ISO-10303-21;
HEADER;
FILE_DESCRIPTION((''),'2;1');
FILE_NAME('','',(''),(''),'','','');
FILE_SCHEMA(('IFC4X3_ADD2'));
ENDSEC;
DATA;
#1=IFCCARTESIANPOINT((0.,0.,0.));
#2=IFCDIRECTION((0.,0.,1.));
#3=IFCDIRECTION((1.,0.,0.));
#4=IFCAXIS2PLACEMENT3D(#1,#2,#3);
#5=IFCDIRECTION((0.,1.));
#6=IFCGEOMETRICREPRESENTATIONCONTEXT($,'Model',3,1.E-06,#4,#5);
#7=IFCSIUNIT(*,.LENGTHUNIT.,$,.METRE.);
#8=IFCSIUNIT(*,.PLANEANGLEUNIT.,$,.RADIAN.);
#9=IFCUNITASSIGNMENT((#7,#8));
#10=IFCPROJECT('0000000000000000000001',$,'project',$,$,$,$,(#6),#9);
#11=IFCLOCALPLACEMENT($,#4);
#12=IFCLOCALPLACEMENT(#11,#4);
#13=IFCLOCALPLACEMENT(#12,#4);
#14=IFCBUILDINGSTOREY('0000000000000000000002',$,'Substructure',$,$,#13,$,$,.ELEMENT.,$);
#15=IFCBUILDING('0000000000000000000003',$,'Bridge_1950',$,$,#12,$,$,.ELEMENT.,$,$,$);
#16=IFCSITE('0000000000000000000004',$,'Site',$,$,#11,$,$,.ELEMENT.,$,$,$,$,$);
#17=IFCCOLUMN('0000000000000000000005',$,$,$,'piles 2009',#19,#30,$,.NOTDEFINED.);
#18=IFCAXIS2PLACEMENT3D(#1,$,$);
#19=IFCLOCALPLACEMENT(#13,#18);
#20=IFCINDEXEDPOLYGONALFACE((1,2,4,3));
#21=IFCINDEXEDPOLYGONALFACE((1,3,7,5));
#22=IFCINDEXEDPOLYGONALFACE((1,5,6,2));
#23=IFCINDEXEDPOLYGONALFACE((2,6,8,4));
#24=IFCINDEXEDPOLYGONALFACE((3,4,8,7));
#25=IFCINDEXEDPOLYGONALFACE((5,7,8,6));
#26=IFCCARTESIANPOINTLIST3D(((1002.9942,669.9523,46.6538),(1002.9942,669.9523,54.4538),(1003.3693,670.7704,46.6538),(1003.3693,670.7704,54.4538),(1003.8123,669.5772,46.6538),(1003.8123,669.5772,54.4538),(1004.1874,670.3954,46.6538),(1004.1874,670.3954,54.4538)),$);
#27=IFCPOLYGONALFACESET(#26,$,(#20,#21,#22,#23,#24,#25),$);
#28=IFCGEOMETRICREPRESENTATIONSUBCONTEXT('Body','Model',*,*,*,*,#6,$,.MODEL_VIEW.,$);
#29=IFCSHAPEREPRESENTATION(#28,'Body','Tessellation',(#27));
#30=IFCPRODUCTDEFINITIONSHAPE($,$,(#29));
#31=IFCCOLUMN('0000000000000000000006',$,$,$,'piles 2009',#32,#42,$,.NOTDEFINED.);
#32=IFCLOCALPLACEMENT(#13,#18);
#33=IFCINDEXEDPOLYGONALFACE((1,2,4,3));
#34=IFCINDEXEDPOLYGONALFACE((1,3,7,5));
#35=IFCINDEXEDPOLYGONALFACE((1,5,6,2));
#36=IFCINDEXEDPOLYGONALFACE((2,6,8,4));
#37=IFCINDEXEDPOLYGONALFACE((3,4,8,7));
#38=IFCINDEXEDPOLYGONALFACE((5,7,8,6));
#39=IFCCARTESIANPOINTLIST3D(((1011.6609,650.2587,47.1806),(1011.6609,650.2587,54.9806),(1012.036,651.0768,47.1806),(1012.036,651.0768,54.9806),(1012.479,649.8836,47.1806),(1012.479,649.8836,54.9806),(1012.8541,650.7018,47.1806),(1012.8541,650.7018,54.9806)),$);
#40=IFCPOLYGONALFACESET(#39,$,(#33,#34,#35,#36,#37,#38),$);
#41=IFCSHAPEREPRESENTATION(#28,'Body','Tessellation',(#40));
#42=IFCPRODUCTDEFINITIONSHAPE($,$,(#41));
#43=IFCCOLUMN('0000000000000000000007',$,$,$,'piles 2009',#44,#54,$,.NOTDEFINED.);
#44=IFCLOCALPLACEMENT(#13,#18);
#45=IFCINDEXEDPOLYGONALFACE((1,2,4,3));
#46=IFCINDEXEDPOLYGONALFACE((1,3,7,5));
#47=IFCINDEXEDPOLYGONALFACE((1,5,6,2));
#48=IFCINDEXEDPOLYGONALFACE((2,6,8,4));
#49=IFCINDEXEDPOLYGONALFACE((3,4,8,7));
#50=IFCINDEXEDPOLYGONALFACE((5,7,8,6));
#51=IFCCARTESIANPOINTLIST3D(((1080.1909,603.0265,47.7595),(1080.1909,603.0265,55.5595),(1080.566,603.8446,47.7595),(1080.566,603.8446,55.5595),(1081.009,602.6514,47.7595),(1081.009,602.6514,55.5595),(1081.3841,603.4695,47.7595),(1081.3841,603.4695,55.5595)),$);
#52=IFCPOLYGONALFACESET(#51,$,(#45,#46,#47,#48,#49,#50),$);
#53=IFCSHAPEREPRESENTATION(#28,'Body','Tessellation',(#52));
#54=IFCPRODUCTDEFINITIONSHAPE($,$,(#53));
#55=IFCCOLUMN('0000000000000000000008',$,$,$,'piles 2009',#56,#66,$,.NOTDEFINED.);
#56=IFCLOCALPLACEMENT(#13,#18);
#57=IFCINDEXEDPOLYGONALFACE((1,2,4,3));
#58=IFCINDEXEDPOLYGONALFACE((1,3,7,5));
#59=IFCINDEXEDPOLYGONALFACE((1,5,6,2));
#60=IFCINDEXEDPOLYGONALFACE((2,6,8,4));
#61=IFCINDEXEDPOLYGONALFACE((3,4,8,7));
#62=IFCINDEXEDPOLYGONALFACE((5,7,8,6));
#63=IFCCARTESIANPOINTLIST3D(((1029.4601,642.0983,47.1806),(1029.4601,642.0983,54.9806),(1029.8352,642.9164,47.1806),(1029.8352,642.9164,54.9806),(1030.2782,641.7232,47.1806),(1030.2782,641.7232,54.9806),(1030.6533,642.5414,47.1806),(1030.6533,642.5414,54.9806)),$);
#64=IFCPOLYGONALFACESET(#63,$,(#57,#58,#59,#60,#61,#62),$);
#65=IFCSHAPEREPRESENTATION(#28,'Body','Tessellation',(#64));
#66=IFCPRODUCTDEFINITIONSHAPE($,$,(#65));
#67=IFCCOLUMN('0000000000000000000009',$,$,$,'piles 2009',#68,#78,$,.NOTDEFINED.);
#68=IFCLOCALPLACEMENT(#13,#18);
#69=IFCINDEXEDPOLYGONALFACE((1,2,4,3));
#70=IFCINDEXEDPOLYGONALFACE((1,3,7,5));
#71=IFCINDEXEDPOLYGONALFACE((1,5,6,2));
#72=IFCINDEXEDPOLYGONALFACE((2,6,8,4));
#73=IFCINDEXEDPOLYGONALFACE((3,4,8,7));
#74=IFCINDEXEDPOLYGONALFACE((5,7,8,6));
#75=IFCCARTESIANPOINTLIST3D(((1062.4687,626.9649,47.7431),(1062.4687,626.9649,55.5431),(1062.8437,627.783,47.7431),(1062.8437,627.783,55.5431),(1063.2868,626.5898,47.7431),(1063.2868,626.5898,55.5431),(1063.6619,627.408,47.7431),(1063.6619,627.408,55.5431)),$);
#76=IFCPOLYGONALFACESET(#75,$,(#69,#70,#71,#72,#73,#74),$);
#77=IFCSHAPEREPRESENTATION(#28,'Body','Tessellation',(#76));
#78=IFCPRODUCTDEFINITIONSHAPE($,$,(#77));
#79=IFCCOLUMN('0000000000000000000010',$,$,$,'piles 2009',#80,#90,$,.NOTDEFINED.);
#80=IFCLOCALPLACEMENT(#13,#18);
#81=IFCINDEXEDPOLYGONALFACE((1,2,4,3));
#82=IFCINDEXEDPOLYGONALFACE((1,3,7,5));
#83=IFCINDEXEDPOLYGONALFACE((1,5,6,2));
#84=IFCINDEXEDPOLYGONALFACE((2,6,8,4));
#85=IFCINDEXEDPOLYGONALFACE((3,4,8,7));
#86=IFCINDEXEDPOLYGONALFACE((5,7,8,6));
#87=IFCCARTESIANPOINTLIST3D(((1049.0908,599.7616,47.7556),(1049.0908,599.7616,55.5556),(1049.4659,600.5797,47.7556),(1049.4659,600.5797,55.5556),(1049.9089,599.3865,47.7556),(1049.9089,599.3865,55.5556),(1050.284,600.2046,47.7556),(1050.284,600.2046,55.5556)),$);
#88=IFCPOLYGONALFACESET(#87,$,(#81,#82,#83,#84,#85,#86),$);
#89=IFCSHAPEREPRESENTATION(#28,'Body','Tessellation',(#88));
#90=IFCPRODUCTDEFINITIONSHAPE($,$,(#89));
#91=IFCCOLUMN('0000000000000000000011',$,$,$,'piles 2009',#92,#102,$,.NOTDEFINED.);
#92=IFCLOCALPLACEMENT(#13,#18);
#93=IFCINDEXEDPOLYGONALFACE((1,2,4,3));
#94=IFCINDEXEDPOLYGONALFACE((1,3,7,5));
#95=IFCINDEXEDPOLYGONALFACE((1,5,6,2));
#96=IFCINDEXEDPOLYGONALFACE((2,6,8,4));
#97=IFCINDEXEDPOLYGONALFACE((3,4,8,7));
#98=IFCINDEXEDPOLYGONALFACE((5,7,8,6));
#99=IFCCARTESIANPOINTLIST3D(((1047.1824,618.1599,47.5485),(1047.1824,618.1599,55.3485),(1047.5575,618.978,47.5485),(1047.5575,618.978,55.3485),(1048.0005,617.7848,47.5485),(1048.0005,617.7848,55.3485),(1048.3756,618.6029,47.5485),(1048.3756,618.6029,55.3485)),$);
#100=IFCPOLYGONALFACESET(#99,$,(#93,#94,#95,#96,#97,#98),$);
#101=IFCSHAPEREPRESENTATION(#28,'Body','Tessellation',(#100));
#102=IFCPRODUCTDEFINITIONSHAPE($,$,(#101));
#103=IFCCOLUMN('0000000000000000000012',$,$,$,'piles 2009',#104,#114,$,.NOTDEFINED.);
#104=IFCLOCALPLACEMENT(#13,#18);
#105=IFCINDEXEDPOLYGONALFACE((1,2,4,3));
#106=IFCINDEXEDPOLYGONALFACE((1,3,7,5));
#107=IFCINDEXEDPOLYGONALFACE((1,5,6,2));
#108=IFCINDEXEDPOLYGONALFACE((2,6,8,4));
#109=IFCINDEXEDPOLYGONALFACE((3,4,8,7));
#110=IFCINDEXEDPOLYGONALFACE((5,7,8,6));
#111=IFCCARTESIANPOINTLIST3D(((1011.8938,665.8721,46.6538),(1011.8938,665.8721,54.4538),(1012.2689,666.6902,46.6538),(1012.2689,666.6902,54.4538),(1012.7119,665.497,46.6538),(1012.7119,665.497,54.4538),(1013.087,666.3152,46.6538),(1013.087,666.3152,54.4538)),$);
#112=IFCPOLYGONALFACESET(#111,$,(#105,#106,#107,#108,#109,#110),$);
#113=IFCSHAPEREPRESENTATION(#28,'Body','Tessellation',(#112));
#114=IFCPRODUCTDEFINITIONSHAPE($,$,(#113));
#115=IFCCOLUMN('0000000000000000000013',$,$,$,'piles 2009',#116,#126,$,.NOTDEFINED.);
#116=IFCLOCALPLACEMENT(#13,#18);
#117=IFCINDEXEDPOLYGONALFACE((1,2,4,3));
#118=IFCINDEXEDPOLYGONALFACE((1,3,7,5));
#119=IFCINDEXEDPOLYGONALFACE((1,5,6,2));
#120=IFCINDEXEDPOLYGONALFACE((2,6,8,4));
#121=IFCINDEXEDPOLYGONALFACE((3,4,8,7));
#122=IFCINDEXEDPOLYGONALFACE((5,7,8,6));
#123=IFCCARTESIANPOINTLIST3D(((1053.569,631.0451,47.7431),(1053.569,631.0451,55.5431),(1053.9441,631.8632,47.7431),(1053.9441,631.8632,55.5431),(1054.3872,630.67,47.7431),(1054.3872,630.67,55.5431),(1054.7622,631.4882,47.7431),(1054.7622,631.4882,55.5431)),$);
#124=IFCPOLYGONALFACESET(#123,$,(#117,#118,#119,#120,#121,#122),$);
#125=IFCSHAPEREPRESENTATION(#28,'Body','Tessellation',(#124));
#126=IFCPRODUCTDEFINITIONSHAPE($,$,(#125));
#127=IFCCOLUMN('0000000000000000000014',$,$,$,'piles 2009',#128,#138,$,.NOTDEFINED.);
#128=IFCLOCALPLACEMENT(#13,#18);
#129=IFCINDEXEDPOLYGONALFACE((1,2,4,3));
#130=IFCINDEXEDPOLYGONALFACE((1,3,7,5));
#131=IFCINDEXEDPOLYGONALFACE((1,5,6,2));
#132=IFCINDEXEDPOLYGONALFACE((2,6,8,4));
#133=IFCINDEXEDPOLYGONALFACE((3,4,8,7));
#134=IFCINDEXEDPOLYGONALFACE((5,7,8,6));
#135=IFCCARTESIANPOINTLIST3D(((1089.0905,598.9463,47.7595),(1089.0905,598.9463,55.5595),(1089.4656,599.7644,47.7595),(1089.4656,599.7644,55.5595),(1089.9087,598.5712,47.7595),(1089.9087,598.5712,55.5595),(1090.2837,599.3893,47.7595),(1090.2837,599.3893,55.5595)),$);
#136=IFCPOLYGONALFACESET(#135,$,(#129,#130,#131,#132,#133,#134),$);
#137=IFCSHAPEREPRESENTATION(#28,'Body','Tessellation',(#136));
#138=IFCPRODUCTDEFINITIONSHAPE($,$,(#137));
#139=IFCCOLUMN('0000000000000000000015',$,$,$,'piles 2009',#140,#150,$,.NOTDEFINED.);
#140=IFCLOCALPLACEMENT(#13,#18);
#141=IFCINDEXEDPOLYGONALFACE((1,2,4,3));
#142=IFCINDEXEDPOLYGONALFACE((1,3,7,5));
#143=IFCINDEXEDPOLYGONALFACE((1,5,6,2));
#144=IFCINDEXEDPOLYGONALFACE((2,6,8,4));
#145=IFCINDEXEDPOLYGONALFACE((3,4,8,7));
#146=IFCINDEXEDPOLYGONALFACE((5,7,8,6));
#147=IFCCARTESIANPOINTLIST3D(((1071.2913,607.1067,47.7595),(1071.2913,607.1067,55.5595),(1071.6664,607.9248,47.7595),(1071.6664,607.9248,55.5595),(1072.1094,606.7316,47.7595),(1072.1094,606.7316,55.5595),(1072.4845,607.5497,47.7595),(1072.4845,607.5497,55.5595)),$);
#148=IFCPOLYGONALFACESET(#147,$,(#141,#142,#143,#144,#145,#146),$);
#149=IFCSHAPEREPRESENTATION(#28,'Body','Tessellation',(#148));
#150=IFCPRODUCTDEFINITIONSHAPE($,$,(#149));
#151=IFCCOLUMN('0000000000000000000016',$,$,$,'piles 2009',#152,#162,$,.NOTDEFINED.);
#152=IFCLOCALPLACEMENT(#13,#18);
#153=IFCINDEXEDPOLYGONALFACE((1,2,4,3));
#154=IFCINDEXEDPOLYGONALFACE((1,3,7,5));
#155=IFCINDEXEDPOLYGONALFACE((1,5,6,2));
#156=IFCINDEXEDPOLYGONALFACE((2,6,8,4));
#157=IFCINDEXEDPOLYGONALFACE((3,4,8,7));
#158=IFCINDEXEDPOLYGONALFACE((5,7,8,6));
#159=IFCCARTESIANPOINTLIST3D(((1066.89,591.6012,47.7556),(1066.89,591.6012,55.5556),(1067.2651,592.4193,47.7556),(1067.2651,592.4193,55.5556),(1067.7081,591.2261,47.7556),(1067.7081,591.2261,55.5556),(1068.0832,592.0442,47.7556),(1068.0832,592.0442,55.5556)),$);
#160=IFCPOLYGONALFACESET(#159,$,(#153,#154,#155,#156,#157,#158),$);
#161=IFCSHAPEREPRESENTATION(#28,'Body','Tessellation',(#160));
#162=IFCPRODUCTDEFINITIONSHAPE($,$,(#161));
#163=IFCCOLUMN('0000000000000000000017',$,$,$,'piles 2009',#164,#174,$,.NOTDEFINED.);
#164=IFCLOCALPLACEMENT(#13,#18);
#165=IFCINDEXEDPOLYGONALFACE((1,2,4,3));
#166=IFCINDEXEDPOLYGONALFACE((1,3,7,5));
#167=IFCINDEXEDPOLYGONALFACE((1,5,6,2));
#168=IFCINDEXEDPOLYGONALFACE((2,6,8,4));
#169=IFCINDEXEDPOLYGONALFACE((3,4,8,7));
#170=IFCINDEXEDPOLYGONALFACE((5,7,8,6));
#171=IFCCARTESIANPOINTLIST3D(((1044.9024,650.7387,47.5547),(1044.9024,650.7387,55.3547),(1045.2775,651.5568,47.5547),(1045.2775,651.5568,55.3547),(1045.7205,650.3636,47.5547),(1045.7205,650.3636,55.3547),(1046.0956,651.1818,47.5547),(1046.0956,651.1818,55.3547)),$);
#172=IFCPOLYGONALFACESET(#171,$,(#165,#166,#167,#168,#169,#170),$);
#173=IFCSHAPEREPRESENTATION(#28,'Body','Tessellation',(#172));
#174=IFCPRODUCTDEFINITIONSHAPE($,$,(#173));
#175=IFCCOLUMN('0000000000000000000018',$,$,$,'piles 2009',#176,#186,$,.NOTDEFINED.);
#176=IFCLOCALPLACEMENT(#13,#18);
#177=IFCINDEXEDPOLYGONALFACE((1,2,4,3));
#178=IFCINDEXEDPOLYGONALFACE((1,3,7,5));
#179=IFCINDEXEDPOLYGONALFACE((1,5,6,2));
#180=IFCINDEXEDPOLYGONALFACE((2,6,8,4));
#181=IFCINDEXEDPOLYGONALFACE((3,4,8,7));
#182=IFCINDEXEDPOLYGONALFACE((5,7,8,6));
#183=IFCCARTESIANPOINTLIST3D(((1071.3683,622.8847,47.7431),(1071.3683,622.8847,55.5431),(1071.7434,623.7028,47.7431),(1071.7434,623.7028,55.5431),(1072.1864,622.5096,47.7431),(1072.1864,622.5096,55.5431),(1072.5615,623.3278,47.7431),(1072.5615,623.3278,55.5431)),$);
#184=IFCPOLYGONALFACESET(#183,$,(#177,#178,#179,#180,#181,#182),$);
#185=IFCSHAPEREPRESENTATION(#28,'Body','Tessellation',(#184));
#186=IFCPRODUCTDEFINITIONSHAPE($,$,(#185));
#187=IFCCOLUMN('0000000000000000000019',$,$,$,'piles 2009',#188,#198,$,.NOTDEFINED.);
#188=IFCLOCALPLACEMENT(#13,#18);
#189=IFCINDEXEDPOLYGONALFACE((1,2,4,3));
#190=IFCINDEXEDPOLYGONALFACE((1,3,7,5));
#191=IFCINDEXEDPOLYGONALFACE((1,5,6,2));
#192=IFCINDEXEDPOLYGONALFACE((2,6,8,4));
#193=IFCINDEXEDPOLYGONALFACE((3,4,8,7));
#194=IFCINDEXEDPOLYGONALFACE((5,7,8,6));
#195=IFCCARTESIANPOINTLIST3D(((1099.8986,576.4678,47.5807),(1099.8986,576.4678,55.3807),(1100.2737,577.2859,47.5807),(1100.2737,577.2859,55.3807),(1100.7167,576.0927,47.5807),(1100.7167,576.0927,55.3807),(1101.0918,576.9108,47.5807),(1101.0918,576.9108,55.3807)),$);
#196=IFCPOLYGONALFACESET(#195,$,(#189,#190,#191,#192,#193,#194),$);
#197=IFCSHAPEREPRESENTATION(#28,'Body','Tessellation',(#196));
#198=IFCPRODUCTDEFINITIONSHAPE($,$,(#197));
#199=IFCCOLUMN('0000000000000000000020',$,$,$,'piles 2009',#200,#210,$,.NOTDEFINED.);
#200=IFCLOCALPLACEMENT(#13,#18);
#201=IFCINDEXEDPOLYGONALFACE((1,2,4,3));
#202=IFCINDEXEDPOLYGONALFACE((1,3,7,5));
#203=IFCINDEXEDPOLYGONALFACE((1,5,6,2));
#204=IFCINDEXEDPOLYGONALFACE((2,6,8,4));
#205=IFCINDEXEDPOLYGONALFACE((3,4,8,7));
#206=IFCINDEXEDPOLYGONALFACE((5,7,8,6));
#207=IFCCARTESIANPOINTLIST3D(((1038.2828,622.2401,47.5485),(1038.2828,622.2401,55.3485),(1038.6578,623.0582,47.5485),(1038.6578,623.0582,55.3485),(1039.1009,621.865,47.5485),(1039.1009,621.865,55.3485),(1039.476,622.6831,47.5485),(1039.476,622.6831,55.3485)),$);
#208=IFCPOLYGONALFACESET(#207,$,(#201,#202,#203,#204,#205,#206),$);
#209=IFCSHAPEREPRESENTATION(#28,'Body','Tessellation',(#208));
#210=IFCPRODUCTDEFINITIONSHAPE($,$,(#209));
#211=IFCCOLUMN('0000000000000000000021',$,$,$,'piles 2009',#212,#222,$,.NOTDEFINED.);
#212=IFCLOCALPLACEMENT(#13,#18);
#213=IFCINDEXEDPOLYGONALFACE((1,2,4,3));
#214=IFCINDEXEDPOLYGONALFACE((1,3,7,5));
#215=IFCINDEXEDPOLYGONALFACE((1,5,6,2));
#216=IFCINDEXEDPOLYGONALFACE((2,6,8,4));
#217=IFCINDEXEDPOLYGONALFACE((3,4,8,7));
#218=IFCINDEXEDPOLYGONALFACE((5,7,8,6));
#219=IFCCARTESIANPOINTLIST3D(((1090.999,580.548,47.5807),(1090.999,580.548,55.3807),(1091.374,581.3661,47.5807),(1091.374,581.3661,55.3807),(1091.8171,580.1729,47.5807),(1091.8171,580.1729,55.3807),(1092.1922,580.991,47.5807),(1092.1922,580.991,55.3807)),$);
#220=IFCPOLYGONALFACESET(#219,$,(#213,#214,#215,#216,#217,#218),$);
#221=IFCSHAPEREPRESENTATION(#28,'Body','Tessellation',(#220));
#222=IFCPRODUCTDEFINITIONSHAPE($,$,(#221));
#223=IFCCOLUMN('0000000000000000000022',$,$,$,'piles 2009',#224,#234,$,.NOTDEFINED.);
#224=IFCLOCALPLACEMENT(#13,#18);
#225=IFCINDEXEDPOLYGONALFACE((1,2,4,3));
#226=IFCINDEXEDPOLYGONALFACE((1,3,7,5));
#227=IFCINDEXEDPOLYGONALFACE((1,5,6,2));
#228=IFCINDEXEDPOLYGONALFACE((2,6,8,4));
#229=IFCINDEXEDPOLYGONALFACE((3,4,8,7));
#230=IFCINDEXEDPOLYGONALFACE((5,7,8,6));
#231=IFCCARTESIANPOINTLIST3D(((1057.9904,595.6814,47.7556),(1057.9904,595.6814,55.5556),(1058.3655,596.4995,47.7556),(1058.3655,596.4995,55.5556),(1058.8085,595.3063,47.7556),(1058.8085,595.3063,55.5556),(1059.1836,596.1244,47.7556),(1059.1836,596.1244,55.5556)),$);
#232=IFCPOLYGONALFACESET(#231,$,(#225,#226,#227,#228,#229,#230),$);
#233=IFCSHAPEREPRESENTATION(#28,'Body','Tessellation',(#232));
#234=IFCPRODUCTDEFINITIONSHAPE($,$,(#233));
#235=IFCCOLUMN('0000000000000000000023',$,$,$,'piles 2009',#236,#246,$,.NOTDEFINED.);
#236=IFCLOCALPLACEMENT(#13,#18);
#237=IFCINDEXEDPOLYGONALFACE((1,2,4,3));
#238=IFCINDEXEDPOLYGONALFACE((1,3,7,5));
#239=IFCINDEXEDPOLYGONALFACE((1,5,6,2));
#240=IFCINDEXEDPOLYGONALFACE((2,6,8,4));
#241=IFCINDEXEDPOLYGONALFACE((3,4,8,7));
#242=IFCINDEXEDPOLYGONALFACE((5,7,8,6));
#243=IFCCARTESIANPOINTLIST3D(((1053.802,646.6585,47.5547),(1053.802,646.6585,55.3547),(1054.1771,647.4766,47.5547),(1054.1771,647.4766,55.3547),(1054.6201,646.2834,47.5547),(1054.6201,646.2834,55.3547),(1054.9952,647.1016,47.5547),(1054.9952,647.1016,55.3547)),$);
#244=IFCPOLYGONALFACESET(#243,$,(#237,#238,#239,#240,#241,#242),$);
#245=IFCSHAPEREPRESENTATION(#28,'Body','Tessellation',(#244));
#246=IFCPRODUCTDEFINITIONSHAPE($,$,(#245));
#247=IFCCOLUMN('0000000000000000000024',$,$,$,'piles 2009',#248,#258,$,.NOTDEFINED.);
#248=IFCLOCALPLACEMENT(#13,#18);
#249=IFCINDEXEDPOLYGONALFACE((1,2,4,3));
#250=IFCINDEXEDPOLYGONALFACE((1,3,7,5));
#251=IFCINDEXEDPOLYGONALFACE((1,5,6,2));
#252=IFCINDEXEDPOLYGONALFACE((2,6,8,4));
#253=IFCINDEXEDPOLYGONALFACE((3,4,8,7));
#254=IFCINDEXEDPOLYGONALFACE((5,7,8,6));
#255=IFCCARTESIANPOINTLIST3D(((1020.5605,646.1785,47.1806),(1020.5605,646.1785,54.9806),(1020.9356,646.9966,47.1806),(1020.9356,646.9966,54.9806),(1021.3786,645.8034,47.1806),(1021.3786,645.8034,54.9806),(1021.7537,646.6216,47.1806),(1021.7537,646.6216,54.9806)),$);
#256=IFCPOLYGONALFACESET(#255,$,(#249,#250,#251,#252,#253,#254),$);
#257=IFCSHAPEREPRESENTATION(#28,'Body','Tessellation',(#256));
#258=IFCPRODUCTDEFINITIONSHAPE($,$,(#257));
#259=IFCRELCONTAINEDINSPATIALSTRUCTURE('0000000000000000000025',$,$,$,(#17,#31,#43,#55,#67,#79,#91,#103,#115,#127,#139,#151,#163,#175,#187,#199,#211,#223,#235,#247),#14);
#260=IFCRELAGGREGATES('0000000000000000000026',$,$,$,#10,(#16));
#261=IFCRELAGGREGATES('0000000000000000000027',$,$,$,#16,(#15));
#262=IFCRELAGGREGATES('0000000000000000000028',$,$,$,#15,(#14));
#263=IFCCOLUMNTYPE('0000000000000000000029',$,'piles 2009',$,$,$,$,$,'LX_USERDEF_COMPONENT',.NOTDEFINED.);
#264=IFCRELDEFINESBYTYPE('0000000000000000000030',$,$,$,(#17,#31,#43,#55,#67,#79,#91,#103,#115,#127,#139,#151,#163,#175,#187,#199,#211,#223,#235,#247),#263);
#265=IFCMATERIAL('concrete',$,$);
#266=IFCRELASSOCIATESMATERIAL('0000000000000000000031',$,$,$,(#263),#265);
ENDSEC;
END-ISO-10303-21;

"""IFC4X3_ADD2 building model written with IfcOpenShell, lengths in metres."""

from ifc_helpers import new_model, si_unit, direction, frame, frame_2d, origin_with_axes, place, context, subcontext, project, spatial, rectangle, extrude, material, type_object, element, save


model = new_model("IFC4X3_ADD2")

# Units and contexts
model_context = context("Model", 3, precision=1e-06, world=origin_with_axes(), true_north=direction((0.0, 1.0)))
body_context = subcontext(model_context, "Body", "Model", "MODEL_VIEW")
ifc_project = project(units=[si_unit("LENGTHUNIT", "METRE"), si_unit("PLANEANGLEUNIT", "RADIAN")], contexts=[model_context])

# Site, building, storey
site_placement = place(None, origin_with_axes())
site = spatial("IfcSite", under=ifc_project, at=site_placement, Name="Site", CompositionType="ELEMENT")
building_placement = place(site_placement, origin_with_axes())
building = spatial("IfcBuilding", under=site, at=building_placement, Name="Bridge_1950", CompositionType="ELEMENT")
storey_placement = place(building_placement, origin_with_axes())
storey = spatial("IfcBuildingStorey", under=building, at=storey_placement, Name="Substructure", CompositionType="ELEMENT")

# Columns
ifc_material = material(Name="concrete")
column_type = type_object("IfcColumnType", Name="piles 2009", ElementType="LX_USERDEF_COMPONENT", PredefinedType="NOTDEFINED", material=ifc_material)
for number, where, z_axis, x_axis in (
    (1, (1003.8123, 669.5772, 46.6538), (0.0, 0.0, 1.0), (0.416757, 0.909018, 0.0)),
    (2, (1012.479, 649.8836, 47.1806), (0.0, 0.0, 1.0), (0.416757, 0.909018, 0.0)),
    (3, (1081.009, 602.6514, 47.7595), (0.0, 0.0, 1.0), (0.416757, 0.909018, 0.0)),
    (4, (1030.2782, 641.7232, 47.1806), (0.0, 0.0, 1.0), (0.416757, 0.909018, 0.0)),
    (5, (1063.2868, 626.5898, 47.7431), (0.0, 0.0, 1.0), (0.416757, 0.909018, 0.0)),
    (6, (1049.9089, 599.3865, 47.7556), (0.0, 0.0, 1.0), (0.416757, 0.909018, 0.0)),
    (7, (1048.0005, 617.7848, 47.5485), (0.0, 0.0, 1.0), (0.416757, 0.909018, 0.0)),
    (8, (1012.7119, 665.497, 46.6538), (0.0, 0.0, 1.0), (0.416757, 0.909018, 0.0)),
    (9, (1054.3872, 630.67, 47.7431), (0.0, 0.0, 1.0), (0.416757, 0.909018, 0.0)),
    (10, (1089.9087, 598.5712, 47.7595), (0.0, 0.0, 1.0), (0.416757, 0.909018, 0.0)),
    (11, (1072.1094, 606.7316, 47.7595), (0.0, 0.0, 1.0), (0.416757, 0.909018, 0.0)),
    (12, (1067.7081, 591.2261, 47.7556), (0.0, 0.0, 1.0), (0.416757, 0.909018, 0.0)),
    (13, (1045.7205, 650.3636, 47.5547), (0.0, 0.0, 1.0), (0.416757, 0.909018, 0.0)),
    (14, (1072.1864, 622.5096, 47.7431), (0.0, 0.0, 1.0), (0.416757, 0.909018, 0.0)),
    (15, (1100.7167, 576.0927, 47.5807), (0.0, 0.0, 1.0), (0.416757, 0.909018, 0.0)),
    (16, (1039.1009, 621.865, 47.5485), (0.0, 0.0, 1.0), (0.416757, 0.909018, 0.0)),
    (17, (1091.8171, 580.1729, 47.5807), (0.0, 0.0, 1.0), (0.416757, 0.909018, 0.0)),
    (18, (1058.8085, 595.3063, 47.7556), (0.0, 0.0, 1.0), (0.416757, 0.909018, 0.0)),
    (19, (1054.6201, 646.2834, 47.5547), (0.0, 0.0, 1.0), (0.416757, 0.909018, 0.0)),
    (20, (1021.3786, 645.8034, 47.1806), (0.0, 0.0, 1.0), (0.416757, 0.909018, 0.0)),
):
    element("IfcColumn", number, at=place(storey_placement, frame(where, z_axis=z_axis, x_axis=x_axis)), inside=storey, type_object=column_type, ObjectType="piles 2009", PredefinedType="NOTDEFINED", context=body_context, shape_type="SweptSolid", body=[
        extrude(rectangle(XDim=0.9, YDim=0.9, at=frame_2d((0.45, 0.45), x_axis=(1.0, 0.0))), origin_with_axes(), (0.0, 0.0, 1.0), 7.8),
    ])

save(model, "model.ifc")
